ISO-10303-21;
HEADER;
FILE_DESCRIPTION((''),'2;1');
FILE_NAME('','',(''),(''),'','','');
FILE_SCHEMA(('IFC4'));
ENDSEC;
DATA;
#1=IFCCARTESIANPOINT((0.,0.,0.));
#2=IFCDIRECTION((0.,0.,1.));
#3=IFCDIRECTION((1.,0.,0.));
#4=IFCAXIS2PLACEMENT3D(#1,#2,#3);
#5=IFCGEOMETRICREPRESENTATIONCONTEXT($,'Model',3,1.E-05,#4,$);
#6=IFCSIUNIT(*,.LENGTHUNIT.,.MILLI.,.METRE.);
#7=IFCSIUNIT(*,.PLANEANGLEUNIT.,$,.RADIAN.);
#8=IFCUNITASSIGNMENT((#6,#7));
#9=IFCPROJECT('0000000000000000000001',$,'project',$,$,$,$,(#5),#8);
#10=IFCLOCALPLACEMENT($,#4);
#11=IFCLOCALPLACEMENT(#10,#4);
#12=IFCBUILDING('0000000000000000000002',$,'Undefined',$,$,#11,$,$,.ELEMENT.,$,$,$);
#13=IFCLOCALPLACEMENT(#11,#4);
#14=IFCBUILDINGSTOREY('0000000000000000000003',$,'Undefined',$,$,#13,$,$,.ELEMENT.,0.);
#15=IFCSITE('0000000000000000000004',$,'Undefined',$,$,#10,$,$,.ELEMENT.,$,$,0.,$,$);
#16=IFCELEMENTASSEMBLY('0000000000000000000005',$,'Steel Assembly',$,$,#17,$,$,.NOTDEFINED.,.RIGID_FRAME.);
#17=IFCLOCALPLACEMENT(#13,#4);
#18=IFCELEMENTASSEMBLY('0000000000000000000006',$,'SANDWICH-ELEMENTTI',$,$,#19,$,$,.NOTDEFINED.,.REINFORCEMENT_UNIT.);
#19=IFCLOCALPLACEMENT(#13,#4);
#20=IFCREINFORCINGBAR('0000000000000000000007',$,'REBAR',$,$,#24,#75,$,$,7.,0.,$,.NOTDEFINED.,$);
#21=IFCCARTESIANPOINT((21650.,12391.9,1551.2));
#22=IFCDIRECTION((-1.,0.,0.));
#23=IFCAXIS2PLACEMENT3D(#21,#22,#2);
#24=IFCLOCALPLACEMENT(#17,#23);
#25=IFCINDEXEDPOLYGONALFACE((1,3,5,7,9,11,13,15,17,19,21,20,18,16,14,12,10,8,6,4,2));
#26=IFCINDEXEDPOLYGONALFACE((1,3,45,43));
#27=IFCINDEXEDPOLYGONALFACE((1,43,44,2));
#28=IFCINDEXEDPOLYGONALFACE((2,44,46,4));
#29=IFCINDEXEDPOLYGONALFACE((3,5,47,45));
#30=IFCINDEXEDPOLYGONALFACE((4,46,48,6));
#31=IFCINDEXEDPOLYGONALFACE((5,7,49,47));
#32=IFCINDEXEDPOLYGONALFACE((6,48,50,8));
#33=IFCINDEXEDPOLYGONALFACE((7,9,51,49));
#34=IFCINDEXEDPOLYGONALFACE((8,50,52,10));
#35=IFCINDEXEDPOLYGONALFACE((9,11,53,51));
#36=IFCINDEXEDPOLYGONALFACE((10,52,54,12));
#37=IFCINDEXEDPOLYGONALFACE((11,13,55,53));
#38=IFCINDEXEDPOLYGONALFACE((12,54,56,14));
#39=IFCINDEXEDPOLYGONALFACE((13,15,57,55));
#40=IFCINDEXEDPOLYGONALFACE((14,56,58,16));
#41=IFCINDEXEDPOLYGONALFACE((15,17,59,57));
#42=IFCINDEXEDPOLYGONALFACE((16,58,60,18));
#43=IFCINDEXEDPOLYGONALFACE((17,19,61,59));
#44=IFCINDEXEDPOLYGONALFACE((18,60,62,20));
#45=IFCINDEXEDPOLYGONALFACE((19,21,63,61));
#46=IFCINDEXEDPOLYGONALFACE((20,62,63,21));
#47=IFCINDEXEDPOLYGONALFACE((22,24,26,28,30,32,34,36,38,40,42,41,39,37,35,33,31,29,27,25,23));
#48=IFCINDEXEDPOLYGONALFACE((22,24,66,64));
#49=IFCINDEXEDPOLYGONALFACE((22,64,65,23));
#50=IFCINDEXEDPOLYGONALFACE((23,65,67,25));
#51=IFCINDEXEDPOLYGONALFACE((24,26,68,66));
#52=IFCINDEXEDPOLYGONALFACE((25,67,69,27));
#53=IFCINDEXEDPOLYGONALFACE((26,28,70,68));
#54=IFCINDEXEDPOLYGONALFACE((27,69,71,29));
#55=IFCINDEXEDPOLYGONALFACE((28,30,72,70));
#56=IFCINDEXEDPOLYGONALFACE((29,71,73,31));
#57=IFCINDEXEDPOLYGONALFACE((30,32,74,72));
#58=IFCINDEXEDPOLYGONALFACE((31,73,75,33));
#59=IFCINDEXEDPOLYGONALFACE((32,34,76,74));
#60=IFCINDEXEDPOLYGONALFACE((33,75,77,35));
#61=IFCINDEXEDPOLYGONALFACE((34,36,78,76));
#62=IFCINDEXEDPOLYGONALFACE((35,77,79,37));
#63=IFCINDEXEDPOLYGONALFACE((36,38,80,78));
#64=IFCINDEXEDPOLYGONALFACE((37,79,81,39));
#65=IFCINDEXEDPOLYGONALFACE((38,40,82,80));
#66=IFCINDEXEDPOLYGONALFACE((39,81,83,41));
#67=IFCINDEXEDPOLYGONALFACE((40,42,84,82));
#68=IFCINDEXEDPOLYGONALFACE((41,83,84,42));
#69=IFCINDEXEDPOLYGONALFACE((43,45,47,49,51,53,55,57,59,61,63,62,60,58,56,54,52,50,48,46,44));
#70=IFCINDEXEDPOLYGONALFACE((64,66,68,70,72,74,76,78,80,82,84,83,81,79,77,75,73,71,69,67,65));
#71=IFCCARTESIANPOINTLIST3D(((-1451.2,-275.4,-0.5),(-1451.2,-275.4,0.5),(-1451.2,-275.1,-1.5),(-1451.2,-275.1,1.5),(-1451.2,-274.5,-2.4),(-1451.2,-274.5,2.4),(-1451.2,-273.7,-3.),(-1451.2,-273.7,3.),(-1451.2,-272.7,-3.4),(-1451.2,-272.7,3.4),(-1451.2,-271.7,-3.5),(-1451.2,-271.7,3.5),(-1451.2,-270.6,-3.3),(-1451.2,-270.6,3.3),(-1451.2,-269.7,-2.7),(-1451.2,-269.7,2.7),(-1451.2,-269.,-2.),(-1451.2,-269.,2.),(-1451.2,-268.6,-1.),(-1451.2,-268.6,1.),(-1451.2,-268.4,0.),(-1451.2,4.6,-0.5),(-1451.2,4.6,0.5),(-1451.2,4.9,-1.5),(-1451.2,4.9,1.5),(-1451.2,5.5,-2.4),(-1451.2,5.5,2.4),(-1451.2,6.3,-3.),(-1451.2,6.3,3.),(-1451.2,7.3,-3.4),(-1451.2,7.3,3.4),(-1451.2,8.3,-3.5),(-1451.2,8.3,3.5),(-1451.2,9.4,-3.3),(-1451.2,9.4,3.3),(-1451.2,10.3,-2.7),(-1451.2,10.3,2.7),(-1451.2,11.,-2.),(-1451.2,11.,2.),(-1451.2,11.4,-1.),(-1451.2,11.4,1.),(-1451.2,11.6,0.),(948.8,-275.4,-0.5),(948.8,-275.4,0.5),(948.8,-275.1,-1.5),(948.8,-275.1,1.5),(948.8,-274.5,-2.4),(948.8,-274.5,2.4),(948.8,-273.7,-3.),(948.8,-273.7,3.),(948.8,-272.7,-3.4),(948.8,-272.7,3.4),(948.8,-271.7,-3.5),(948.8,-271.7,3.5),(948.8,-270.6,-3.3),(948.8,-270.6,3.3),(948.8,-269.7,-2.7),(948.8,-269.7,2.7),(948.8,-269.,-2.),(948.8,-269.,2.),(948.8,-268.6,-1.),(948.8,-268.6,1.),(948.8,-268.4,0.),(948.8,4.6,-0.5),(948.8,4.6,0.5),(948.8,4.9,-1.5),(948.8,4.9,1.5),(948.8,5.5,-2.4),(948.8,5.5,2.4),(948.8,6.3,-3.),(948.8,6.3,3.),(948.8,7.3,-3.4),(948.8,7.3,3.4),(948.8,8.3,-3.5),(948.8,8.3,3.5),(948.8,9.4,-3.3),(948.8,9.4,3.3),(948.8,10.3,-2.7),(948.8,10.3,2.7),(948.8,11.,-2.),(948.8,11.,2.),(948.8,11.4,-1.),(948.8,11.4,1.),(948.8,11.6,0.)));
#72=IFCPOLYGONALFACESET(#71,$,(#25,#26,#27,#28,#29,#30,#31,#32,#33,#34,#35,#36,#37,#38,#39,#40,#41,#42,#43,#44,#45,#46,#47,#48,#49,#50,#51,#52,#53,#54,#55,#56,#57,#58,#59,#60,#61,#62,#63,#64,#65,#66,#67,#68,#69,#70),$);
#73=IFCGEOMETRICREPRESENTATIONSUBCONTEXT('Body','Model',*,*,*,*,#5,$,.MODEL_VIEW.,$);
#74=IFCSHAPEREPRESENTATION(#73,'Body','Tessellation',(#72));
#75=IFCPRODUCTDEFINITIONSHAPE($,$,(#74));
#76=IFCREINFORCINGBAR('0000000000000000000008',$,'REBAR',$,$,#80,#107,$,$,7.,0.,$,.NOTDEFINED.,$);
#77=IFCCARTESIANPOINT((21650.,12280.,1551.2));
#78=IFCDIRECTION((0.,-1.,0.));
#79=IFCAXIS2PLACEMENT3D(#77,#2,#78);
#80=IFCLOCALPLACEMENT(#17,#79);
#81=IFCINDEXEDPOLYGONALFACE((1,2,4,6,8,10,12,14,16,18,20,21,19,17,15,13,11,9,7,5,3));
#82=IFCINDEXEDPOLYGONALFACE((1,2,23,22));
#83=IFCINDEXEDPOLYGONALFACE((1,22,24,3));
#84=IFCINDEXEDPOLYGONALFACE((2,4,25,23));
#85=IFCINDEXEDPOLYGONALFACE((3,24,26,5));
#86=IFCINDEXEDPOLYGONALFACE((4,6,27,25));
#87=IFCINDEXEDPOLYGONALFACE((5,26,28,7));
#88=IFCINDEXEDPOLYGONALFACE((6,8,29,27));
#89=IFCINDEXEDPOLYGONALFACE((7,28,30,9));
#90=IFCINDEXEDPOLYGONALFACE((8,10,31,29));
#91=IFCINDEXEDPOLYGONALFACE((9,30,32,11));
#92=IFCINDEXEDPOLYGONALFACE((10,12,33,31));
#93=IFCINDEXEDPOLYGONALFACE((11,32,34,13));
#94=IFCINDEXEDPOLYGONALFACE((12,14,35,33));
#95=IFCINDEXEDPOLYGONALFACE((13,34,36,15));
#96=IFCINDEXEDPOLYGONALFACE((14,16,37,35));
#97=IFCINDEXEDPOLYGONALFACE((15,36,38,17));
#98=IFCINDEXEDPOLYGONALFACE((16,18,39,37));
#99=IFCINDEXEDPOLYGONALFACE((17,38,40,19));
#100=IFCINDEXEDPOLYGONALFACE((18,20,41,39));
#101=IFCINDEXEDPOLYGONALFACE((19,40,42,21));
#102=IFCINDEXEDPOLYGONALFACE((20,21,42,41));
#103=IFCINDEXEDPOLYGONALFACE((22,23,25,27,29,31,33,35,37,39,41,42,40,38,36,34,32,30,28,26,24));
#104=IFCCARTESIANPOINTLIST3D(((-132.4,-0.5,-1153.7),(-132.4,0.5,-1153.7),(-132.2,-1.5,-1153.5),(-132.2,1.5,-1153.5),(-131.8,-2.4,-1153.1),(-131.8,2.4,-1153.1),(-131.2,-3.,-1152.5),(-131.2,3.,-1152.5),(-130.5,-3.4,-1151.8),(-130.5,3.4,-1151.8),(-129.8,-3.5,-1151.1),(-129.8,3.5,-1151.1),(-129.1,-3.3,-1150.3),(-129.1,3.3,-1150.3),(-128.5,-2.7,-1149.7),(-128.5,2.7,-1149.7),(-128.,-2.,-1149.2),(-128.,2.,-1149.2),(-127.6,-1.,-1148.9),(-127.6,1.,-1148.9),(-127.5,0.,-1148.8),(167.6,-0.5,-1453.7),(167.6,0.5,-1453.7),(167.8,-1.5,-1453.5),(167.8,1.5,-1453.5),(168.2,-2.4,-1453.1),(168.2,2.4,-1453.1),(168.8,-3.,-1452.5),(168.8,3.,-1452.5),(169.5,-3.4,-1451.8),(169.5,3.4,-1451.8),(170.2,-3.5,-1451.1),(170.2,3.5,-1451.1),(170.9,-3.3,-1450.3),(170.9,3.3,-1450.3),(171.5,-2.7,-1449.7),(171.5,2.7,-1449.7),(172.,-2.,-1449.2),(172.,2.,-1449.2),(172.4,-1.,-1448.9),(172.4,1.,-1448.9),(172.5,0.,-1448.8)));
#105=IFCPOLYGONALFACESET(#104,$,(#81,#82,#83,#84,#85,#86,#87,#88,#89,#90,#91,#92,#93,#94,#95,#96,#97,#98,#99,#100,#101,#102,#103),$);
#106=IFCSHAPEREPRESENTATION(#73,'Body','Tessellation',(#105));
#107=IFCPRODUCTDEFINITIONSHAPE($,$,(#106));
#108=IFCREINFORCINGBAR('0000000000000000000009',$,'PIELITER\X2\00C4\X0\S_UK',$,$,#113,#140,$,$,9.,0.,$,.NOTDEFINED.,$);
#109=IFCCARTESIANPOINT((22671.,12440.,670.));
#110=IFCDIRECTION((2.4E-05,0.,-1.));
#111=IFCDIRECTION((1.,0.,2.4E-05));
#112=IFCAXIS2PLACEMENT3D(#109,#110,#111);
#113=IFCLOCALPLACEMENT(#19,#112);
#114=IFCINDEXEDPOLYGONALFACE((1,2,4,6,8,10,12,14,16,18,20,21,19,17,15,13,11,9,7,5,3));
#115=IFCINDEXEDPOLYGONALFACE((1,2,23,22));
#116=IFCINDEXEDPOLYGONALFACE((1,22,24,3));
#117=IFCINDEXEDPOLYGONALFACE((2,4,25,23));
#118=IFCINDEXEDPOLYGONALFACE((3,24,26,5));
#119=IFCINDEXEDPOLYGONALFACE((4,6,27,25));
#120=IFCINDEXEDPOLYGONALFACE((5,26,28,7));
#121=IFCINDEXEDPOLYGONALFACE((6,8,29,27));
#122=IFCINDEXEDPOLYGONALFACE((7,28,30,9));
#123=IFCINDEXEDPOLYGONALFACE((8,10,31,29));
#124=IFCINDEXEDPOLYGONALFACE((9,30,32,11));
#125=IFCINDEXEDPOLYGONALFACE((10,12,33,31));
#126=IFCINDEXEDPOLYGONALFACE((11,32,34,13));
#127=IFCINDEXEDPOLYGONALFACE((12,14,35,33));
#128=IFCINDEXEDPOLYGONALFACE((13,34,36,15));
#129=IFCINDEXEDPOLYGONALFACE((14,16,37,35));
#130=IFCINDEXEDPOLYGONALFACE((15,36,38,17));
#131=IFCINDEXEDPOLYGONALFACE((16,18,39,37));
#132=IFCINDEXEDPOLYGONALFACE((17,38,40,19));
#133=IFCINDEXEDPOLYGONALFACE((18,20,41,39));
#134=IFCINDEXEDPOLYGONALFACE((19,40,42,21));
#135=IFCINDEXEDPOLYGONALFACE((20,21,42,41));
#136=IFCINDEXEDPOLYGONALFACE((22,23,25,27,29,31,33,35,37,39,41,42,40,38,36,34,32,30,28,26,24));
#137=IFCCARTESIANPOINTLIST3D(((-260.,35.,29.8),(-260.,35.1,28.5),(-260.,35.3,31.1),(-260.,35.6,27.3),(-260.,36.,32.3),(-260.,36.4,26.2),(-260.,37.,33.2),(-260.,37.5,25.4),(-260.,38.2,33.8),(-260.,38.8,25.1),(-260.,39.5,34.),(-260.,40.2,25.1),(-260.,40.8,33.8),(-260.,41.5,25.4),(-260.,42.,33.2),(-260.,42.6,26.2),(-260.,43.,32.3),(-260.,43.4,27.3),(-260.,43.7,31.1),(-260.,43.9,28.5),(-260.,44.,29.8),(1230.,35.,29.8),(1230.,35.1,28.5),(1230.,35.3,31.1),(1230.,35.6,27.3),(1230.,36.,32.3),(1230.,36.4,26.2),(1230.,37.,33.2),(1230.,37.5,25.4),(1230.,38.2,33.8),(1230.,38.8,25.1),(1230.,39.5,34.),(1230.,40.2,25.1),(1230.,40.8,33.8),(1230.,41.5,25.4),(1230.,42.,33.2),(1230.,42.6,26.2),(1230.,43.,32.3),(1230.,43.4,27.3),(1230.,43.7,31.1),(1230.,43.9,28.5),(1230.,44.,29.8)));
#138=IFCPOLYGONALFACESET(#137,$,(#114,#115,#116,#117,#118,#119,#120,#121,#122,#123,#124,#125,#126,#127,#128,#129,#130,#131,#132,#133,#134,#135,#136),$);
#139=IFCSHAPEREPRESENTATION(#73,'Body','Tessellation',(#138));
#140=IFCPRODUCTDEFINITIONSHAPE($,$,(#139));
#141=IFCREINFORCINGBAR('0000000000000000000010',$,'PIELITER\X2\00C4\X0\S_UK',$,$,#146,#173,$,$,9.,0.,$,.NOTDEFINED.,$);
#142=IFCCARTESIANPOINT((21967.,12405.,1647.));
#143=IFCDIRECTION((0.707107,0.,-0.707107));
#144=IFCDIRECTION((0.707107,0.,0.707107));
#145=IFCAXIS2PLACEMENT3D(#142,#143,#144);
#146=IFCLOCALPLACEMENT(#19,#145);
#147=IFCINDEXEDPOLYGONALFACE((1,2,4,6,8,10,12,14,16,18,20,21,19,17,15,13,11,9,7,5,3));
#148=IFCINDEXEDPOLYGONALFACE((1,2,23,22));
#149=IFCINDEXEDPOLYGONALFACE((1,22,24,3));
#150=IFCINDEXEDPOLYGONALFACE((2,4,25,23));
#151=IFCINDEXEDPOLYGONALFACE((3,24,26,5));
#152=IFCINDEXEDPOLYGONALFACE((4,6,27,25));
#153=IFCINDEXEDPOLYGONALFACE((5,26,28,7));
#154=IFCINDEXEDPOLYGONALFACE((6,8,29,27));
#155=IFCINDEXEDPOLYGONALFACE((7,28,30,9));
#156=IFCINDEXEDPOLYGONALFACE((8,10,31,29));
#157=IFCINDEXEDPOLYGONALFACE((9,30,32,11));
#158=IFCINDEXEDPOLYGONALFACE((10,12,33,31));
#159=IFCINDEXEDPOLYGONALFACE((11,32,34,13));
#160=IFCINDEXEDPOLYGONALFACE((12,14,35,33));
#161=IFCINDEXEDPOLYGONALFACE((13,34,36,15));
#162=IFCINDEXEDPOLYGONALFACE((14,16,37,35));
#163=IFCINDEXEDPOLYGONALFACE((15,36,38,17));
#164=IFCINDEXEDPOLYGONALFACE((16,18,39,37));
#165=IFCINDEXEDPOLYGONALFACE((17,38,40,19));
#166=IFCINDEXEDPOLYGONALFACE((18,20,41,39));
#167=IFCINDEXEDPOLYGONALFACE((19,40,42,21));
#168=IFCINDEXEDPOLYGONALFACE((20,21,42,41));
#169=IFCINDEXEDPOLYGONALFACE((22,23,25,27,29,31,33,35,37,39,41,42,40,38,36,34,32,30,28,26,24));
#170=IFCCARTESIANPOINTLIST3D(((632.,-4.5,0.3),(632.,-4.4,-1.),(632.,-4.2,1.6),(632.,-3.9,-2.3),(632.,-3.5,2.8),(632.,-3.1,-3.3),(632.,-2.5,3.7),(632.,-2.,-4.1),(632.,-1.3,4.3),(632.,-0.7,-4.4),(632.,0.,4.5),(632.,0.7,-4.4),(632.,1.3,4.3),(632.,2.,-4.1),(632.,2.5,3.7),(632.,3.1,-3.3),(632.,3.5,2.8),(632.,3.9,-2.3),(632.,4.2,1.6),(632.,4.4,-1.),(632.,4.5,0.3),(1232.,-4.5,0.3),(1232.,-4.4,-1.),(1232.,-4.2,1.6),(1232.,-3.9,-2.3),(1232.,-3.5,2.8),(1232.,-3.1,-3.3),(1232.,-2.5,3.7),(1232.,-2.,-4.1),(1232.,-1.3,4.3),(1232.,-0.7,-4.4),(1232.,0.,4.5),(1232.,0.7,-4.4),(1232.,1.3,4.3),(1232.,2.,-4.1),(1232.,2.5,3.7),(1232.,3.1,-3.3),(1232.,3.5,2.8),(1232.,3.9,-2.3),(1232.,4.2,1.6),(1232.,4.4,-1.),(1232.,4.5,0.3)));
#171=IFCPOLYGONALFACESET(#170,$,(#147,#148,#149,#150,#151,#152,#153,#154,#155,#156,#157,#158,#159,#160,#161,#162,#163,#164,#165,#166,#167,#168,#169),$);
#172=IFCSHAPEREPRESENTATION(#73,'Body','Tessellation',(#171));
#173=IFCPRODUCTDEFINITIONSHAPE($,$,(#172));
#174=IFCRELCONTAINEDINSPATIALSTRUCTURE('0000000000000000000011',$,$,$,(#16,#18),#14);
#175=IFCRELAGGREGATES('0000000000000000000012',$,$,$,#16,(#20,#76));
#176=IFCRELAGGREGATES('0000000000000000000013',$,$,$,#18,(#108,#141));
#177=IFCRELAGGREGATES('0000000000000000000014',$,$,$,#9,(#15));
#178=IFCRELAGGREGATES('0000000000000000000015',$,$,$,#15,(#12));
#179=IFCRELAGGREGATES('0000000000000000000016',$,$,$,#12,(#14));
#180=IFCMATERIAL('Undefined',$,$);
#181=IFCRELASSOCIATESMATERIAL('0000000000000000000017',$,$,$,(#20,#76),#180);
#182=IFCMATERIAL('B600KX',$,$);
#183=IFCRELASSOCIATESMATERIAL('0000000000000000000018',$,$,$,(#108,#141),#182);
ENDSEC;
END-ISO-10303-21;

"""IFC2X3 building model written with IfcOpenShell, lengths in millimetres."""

from ifc_helpers import new_model, entity, si_unit, frame, origin_with_axes, place, context, subcontext, project, spatial, source, transform, mapped, material, element, aggregate, save


model = new_model("IFC2X3")

# Units and contexts
model_context = context("Model", 3, precision=1e-05, world=origin_with_axes())
body_context = subcontext(model_context, "Body", "Model", "MODEL_VIEW")
ifc_project = project(units=[si_unit("LENGTHUNIT", "METRE", prefix="MILLI"), si_unit("PLANEANGLEUNIT", "RADIAN")], contexts=[model_context])

# Site, building, storey
site_placement = place(None, origin_with_axes())
site = spatial("IfcSite", under=ifc_project, at=site_placement, Name="Undefined", CompositionType="ELEMENT", RefElevation=0.0)
building_placement = place(site_placement, origin_with_axes())
building = spatial("IfcBuilding", under=site, at=building_placement, Name="Undefined", CompositionType="ELEMENT")
storey_placement = place(building_placement, origin_with_axes())
storey = spatial("IfcBuildingStorey", under=building, at=storey_placement, Name="Undefined", CompositionType="ELEMENT", Elevation=0.0)

# Element assembly
assembly_1_placement = place(storey_placement, origin_with_axes())
assembly_1 = element("IfcElementAssembly", 1, at=assembly_1_placement, inside=storey, Name="Steel Assembly", AssemblyPlace="NOTDEFINED", PredefinedType="RIGID_FRAME")

# Element assembly
assembly_2_placement = place(storey_placement, origin_with_axes())
assembly_2 = element("IfcElementAssembly", 2, at=assembly_2_placement, inside=storey, Name="SANDWICH-ELEMENTTI", AssemblyPlace="NOTDEFINED", PredefinedType="REINFORCEMENT_UNIT")

# Shared definitions
ifc_material_1 = material(Name="Undefined")

# Reinforcing bars
shared_shape_1 = source(origin_with_axes(), body_context, "Body", "AdvancedSweptSolid", [
    entity("IfcSweptDiskSolid", entity("IfcTrimmedCurve", entity("IfcLine", entity("IfcCartesianPoint", [0.0, 0.0, 0.0]), entity("IfcVector", entity("IfcDirection", [1.0, 0.000003, 0.0]), 1.0)), [entity("IfcParameterValue", 0.0)], [entity("IfcParameterValue", 2400.0)], True, "PARAMETER"), 3.5, None, 0.0, 2400.0),
])
shared_shape_2 = source(origin_with_axes(), body_context, "Body", "AdvancedSweptSolid", [
    entity("IfcSweptDiskSolid", entity("IfcTrimmedCurve", entity("IfcLine", entity("IfcCartesianPoint", [0.0, 0.0, 0.0]), entity("IfcVector", entity("IfcDirection", [1.0, 0.000003, 0.0]), 1.0)), [entity("IfcParameterValue", 0.0)], [entity("IfcParameterValue", 2400.0)], True, "PARAMETER"), 3.5, None, 0.0, 2400.0),
])
reinforcing_bar_1_placement = place(assembly_1_placement, frame((21650.0, 12391.9, 1551.2), z_axis=(-1.0, 0.0, 0.0), x_axis=(0.0, 0.0, 1.0)))
reinforcing_bar_1 = element("IfcReinforcingBar", 3, at=reinforcing_bar_1_placement, material=ifc_material_1, Name="REBAR", BarRole="NOTDEFINED", CrossSectionArea=0.0, NominalDiameter=7.0, context=body_context, shape_type="MappedRepresentation", body=[
    mapped(shared_shape_1, transform((-1451.2, -271.9, 0.0))),
    mapped(shared_shape_2, transform((-1451.2, 8.1, 0.0))),
])
shared_shape_3 = source(origin_with_axes(), body_context, "Body", "AdvancedSweptSolid", [
    entity("IfcSweptDiskSolid", entity("IfcTrimmedCurve", entity("IfcLine", entity("IfcCartesianPoint", [0.0, 0.0, 0.0]), entity("IfcVector", entity("IfcDirection", [0.707107, 0.0, -0.707107]), 1.0)), [entity("IfcParameterValue", 0.0)], [entity("IfcParameterValue", 424.264069)], True, "PARAMETER"), 3.5, None, 0.0, 424.3),
])
reinforcing_bar_2_placement = place(assembly_1_placement, frame((21650.0, 12280.0, 1551.2), z_axis=(0.0, 0.0, 1.0), x_axis=(0.0, -1.0, 0.0)))
reinforcing_bar_2 = element("IfcReinforcingBar", 4, at=reinforcing_bar_2_placement, material=ifc_material_1, Name="REBAR", BarRole="NOTDEFINED", CrossSectionArea=0.0, NominalDiameter=7.0, context=body_context, shape_type="MappedRepresentation", body=[
    mapped(shared_shape_3, transform((-130.0, 0.0, -1151.2))),
])
aggregate(assembly_1, [reinforcing_bar_1, reinforcing_bar_2])

# Reinforcing bars
ifc_material_2 = material(Name="B600KX")
shared_shape_4 = source(origin_with_axes(), body_context, "Body", "AdvancedSweptSolid", [
    entity("IfcSweptDiskSolid", entity("IfcTrimmedCurve", entity("IfcLine", entity("IfcCartesianPoint", [0.0, 0.0, 0.0]), entity("IfcVector", entity("IfcDirection", [1.0, 0.0, 0.0]), 1.0)), [entity("IfcParameterValue", 0.0)], [entity("IfcParameterValue", 1490.0003)], True, "PARAMETER"), 4.5, None, 0.0, 1490.0),
])
reinforcing_bar_3_placement = place(assembly_2_placement, frame((22671.0, 12440.0, 670.0), z_axis=(0.000024, 0.0, -1.0), x_axis=(1.0, 0.0, 0.000024)))
reinforcing_bar_3 = element("IfcReinforcingBar", 5, at=reinforcing_bar_3_placement, material=ifc_material_2, Name="PIELITERÄS_UK", BarRole="NOTDEFINED", CrossSectionArea=0.0, NominalDiameter=9.0, context=body_context, shape_type="MappedRepresentation", body=[
    mapped(shared_shape_4, transform((-260.0, 39.5, 29.5))),
])
shared_shape_5 = source(origin_with_axes(), body_context, "Body", "AdvancedSweptSolid", [
    entity("IfcSweptDiskSolid", entity("IfcTrimmedCurve", entity("IfcLine", entity("IfcCartesianPoint", [0.0, 0.0, 0.0]), entity("IfcVector", entity("IfcDirection", [1.0, 0.0, 0.0]), 1.0)), [entity("IfcParameterValue", 0.0)], [entity("IfcParameterValue", 600.0)], True, "PARAMETER"), 4.5, None, 0.0, 600.0),
])
reinforcing_bar_4_placement = place(assembly_2_placement, frame((21967.0, 12405.0, 1647.0), z_axis=(0.707107, 0.0, -0.707107), x_axis=(0.707107, 0.0, 0.707107)))
reinforcing_bar_4 = element("IfcReinforcingBar", 6, at=reinforcing_bar_4_placement, material=ifc_material_2, Name="PIELITERÄS_UK", BarRole="NOTDEFINED", CrossSectionArea=0.0, NominalDiameter=9.0, context=body_context, shape_type="MappedRepresentation", body=[
    mapped(shared_shape_5, transform((632.0, 0.0, 0.0))),
])
aggregate(assembly_2, [reinforcing_bar_3, reinforcing_bar_4])

save(model, "model.ifc")
